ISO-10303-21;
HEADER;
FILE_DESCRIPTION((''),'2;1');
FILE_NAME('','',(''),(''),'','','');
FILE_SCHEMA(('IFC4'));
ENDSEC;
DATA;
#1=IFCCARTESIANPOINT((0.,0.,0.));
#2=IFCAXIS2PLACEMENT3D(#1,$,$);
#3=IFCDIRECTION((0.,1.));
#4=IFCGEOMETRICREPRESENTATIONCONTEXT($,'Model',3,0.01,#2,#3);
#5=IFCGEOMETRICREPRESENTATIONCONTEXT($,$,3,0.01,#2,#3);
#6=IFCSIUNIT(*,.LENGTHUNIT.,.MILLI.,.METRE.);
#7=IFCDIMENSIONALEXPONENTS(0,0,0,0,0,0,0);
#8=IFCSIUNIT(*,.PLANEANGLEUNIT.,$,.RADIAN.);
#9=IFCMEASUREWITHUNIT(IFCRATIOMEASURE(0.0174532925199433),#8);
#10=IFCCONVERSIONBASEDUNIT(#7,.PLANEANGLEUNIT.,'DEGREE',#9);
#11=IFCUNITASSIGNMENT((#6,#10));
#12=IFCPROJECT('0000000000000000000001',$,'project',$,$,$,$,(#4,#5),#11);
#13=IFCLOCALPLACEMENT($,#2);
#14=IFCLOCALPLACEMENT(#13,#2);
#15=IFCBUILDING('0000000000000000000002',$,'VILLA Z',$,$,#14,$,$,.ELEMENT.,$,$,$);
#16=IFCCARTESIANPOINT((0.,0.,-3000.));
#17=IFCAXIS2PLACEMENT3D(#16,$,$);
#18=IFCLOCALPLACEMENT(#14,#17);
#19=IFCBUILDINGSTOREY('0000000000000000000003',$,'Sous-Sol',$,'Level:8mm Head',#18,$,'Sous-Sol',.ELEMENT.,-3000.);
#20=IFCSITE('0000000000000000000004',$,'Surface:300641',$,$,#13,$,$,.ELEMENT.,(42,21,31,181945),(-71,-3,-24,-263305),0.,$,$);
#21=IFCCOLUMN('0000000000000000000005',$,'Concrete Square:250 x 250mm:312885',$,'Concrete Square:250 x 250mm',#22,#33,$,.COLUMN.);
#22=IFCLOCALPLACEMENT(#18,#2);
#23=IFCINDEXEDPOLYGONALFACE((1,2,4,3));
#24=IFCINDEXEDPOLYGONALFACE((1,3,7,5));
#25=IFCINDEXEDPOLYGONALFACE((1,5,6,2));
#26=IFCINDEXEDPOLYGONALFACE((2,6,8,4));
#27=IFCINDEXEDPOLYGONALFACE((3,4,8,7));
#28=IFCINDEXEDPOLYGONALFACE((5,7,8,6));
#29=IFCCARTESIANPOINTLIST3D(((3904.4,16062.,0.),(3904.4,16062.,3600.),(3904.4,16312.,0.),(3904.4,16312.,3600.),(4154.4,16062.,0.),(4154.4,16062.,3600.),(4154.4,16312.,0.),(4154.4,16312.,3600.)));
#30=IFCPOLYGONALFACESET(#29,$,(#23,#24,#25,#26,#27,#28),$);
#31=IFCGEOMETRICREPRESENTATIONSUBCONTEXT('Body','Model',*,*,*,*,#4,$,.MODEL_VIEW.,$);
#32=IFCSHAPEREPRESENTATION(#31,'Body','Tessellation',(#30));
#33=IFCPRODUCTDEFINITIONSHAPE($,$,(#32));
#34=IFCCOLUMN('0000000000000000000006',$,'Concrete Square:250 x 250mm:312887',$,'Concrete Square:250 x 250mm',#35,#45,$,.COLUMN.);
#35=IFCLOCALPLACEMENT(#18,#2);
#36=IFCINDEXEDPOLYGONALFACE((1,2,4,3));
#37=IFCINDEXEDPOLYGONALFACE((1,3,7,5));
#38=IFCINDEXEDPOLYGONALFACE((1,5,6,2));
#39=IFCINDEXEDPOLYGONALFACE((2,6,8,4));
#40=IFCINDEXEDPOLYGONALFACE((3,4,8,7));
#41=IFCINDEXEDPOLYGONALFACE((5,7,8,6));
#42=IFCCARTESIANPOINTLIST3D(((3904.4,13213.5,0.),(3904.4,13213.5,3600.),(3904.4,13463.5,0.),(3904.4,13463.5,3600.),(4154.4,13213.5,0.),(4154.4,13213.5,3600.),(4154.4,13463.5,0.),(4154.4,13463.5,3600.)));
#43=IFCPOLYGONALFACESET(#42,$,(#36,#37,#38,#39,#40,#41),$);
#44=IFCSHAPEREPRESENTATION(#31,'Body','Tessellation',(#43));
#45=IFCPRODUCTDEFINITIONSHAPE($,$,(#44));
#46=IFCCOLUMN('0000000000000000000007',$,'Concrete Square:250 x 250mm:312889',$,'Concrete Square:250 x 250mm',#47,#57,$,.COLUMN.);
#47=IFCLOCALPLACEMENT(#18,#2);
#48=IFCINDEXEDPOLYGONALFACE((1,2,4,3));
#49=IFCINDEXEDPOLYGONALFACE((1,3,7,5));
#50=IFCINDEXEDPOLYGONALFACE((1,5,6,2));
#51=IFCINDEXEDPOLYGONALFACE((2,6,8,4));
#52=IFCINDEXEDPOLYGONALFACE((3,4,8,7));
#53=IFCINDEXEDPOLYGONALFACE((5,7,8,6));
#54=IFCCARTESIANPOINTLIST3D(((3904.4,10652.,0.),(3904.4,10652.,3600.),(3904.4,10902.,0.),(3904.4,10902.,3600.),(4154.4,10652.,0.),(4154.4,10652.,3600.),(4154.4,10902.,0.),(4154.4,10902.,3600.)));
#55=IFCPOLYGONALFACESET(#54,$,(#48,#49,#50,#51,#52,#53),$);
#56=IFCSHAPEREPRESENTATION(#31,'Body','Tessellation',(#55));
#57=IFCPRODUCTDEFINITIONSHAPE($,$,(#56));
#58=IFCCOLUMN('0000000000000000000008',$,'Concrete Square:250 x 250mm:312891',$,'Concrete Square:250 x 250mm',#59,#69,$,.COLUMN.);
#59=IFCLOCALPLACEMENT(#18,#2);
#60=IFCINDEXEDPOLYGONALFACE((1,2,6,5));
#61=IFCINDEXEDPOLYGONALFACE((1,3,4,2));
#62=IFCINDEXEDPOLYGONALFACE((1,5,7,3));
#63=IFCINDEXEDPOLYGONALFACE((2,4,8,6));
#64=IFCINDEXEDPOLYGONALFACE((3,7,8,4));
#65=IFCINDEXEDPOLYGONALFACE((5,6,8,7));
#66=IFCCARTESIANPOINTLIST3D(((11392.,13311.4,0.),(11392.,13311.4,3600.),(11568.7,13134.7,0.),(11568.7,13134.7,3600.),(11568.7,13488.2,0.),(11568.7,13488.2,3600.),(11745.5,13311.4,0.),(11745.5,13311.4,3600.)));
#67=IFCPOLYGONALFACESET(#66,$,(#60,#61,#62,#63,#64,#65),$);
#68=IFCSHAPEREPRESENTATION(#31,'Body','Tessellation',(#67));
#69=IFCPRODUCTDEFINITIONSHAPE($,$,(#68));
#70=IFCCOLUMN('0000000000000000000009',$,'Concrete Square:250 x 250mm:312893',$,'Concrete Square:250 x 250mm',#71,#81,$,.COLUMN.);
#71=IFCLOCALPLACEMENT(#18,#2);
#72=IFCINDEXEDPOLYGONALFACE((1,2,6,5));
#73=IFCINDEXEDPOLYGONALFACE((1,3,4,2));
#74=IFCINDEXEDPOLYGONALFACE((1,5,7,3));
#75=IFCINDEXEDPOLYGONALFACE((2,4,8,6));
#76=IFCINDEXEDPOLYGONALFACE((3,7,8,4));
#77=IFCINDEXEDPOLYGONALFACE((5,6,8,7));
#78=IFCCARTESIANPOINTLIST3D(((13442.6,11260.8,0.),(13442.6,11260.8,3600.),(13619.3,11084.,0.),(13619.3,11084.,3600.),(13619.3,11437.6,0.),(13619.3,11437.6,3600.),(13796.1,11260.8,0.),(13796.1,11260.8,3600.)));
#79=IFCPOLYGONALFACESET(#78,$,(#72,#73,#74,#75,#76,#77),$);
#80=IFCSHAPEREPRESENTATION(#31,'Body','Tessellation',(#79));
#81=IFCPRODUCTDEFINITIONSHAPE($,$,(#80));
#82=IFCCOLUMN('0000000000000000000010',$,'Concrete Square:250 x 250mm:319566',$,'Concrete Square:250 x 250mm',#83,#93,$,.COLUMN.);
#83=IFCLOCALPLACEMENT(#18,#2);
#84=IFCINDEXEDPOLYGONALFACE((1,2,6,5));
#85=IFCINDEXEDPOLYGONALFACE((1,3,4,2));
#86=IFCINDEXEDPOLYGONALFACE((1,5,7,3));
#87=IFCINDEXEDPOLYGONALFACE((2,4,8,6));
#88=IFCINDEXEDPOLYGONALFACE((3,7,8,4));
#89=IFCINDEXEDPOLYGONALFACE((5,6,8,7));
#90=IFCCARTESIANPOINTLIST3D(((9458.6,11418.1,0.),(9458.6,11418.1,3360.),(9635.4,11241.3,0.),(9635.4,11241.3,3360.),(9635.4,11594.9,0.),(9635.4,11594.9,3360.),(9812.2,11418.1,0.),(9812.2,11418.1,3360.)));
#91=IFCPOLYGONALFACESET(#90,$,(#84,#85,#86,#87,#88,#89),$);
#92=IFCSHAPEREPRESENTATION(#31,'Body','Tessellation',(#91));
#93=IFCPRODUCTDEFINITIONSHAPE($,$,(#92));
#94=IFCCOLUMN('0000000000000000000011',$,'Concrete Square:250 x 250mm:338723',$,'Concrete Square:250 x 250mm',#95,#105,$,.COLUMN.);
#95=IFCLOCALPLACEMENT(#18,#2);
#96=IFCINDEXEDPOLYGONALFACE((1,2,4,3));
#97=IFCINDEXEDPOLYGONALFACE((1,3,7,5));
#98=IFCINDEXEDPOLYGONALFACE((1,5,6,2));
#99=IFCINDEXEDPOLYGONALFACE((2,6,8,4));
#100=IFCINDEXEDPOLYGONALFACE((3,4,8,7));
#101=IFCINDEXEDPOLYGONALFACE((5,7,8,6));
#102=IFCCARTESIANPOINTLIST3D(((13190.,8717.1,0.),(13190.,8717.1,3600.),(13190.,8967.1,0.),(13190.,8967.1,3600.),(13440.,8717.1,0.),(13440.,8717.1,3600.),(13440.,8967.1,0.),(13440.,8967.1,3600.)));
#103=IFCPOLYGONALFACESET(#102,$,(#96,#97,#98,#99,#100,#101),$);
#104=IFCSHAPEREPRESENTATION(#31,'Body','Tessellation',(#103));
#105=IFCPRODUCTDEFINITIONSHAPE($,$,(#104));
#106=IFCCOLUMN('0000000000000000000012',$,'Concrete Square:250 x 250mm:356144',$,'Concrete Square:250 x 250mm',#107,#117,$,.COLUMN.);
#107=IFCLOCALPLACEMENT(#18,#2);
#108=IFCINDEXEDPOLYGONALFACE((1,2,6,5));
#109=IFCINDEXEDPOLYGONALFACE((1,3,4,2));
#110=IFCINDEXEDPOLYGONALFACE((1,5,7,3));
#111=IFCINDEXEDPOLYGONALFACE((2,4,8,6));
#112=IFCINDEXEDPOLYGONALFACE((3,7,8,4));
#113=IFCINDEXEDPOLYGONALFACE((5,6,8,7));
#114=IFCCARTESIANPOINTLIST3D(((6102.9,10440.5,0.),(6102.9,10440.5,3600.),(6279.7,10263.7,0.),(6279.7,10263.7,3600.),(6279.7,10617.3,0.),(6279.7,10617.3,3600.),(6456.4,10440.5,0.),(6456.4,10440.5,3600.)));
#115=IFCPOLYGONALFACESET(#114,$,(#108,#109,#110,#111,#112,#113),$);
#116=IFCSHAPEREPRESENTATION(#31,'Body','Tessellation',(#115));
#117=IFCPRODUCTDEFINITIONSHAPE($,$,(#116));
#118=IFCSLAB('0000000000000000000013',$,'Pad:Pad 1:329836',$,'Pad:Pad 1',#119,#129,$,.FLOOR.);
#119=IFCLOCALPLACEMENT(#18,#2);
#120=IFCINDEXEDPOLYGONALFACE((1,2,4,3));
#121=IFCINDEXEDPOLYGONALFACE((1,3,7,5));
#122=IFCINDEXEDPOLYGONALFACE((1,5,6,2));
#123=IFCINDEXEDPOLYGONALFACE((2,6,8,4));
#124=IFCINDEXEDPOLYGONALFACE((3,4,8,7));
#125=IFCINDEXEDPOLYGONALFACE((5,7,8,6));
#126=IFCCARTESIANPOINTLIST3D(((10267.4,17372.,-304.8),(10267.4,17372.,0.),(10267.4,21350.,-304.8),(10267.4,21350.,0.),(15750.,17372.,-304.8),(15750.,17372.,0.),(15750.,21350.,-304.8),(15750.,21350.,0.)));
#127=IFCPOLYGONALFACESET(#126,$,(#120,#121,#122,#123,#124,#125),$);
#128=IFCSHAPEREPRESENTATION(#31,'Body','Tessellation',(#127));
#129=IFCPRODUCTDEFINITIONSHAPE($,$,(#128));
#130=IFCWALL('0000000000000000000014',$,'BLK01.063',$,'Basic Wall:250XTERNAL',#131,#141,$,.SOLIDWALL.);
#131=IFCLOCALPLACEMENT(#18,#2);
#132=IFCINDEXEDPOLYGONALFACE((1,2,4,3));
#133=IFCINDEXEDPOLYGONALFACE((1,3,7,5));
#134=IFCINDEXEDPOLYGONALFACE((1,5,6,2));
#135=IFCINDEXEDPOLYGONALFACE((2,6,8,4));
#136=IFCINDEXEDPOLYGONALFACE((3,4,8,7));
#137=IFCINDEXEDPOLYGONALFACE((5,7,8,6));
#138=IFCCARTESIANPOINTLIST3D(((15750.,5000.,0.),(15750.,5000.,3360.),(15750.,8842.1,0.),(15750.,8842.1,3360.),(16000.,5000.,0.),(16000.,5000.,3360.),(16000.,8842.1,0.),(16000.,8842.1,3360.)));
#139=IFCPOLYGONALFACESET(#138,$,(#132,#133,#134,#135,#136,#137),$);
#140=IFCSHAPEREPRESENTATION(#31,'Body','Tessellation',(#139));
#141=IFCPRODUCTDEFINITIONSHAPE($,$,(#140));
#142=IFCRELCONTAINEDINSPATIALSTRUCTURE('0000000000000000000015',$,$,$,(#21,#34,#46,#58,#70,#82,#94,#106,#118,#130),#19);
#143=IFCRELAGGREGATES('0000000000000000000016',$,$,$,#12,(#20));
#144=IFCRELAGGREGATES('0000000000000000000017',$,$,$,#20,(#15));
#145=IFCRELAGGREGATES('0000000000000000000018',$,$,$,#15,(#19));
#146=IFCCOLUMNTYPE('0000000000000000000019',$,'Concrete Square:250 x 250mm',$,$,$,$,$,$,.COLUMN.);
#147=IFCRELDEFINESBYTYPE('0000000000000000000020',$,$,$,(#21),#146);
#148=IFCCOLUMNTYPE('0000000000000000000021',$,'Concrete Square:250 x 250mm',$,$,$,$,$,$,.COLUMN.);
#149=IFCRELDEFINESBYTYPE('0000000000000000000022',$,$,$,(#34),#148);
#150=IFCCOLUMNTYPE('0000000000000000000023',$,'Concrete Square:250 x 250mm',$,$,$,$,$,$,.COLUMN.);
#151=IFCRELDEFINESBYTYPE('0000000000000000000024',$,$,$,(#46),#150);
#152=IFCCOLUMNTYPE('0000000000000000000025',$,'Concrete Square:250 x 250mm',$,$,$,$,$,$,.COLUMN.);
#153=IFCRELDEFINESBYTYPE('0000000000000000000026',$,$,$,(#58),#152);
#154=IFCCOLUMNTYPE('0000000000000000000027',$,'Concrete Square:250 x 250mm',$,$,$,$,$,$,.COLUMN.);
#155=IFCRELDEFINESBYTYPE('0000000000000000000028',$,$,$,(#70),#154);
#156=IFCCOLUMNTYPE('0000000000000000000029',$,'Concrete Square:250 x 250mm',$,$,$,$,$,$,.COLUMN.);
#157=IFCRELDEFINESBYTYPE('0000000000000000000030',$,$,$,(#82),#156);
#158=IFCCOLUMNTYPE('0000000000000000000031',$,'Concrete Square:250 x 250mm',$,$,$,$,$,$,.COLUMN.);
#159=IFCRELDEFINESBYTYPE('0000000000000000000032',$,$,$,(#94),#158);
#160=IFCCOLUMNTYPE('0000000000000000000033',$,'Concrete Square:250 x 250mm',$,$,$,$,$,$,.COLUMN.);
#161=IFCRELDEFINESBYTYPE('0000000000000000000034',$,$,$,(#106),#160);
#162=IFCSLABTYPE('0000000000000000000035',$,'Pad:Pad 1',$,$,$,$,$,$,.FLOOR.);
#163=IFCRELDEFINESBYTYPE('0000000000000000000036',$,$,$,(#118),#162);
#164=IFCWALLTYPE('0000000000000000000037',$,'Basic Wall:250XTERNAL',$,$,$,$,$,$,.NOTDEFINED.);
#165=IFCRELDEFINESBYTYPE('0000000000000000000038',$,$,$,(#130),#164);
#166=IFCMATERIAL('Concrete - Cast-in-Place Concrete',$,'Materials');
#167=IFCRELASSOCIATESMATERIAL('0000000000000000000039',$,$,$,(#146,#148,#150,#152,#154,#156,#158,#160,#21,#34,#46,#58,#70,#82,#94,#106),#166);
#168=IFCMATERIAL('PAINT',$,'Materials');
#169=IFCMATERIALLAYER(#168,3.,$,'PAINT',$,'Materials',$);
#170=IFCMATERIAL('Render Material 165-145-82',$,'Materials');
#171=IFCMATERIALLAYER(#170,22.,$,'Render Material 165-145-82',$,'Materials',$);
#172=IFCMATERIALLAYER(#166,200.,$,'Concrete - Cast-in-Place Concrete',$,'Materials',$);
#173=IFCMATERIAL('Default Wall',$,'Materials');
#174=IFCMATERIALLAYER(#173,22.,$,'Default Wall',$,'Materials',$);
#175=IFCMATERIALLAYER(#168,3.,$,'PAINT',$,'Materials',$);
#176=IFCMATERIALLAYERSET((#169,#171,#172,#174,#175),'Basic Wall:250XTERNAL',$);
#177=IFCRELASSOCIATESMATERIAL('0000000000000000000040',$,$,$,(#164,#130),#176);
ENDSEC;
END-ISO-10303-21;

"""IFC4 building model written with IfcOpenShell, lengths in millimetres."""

from ifc_helpers import new_model, entity, si_unit, converted_unit, direction, frame, frame_2d, origin, origin_2d_with_axis, place, context, subcontext, project, spatial, polyline, rectangle, extrude, clip, halfspace, bounded_halfspace, source, transform, mapped, material, layer, layer_set, layer_usage, material_profile, profile_set, profile_usage, type_object, type_shapes, element, save


model = new_model("IFC4")

# Units and contexts
model_context = context("Model", 3, precision=0.01, world=origin(), true_north=direction((0.0, 1.0)))
context_of_model = context(None, 3, precision=0.01, world=origin(), true_north=direction((0.0, 1.0)))
body_context = subcontext(model_context, "Body", "Model", "MODEL_VIEW")
ifc_project = project(units=[si_unit("LENGTHUNIT", "METRE", prefix="MILLI"), converted_unit("PLANEANGLEUNIT", "DEGREE", entity("IfcRatioMeasure", 0.0174532925199433), si_unit("PLANEANGLEUNIT", "RADIAN"), dimensions=[0, 0, 0, 0, 0, 0, 0])], contexts=[model_context, context_of_model])

# Site, building, storey
site_placement = place(None, origin())
site = spatial("IfcSite", under=ifc_project, at=site_placement, Name="Surface:300641", CompositionType="ELEMENT", RefLatitude=(42, 21, 31, 181945), RefLongitude=(-71, -3, -24, -263305), RefElevation=0.0)
building_placement = place(site_placement, origin())
building = spatial("IfcBuilding", under=site, at=building_placement, Name="VILLA Z", CompositionType="ELEMENT")
storey_placement = place(building_placement, frame((0.0, 0.0, -3000.0)))
storey = spatial("IfcBuildingStorey", under=building, at=storey_placement, Name="Sous-Sol", ObjectType="Level:8mm Head", LongName="Sous-Sol", CompositionType="ELEMENT", Elevation=-3000.0)

# Columns
ifc_material_1 = material(Name="Concrete - Cast-in-Place Concrete", Category="Materials")
ifc_material_profile = material_profile(ifc_material_1, rectangle(XDim=250.0, YDim=250.0, at=frame_2d((0.0, 0.0), x_axis=(1.0, 0.0))), Name="250 x 250mm")
ifc_profile_set = profile_set([ifc_material_profile], Name="250 x 250mm")
ifc_profile_usage_1 = profile_usage(ifc_profile_set)
column_type_1 = type_object("IfcColumnType", Name="Concrete Square:250 x 250mm", PredefinedType="COLUMN", material=ifc_profile_set)
shared_shape_1 = source(origin(), body_context, "Body", "SweptSolid", [
    extrude(rectangle(XDim=250.0, YDim=250.0, at=frame_2d((0.0, 0.0), x_axis=(1.0, 0.0))), frame((4029.4, 16187.0, -3000.0), z_axis=(0.0, 0.0, 1.0), x_axis=(0.0, -1.0, 0.0)), (0.0, 0.0, 1.0), 3600.0),
])
type_shapes(column_type_1, [shared_shape_1])
column_1_placement = place(storey_placement, frame((0.0, 0.0, 3000.0)))
element("IfcColumn", 1, at=column_1_placement, inside=storey, type_object=column_type_1, material=ifc_profile_usage_1, Name="Concrete Square:250 x 250mm:312885", ObjectType="Concrete Square:250 x 250mm", PredefinedType="COLUMN", context=body_context, shape_type="MappedRepresentation", body=[
    mapped(shared_shape_1, transform((0.0, 0.0, 0.0), scale=1.0)),
])
ifc_profile_usage_2 = profile_usage(ifc_profile_set)
column_type_2 = type_object("IfcColumnType", Name="Concrete Square:250 x 250mm", PredefinedType="COLUMN", material=ifc_profile_set)
shared_shape_2 = source(origin(), body_context, "Body", "SweptSolid", [
    extrude(rectangle(XDim=250.0, YDim=250.0, at=frame_2d((0.0, 0.0), x_axis=(1.0, 0.0))), frame((4029.4, 13338.5, -3000.0), z_axis=(0.0, 0.0, 1.0), x_axis=(0.0, -1.0, 0.0)), (0.0, 0.0, 1.0), 3600.0),
])
type_shapes(column_type_2, [shared_shape_2])
column_2_placement = place(storey_placement, frame((0.0, 0.0, 3000.0)))
element("IfcColumn", 2, at=column_2_placement, inside=storey, type_object=column_type_2, material=ifc_profile_usage_2, Name="Concrete Square:250 x 250mm:312887", ObjectType="Concrete Square:250 x 250mm", PredefinedType="COLUMN", context=body_context, shape_type="MappedRepresentation", body=[
    mapped(shared_shape_2, transform((0.0, 0.0, 0.0), scale=1.0)),
])
ifc_profile_usage_3 = profile_usage(ifc_profile_set)
column_type_3 = type_object("IfcColumnType", Name="Concrete Square:250 x 250mm", PredefinedType="COLUMN", material=ifc_profile_set)
shared_shape_3 = source(origin(), body_context, "Body", "SweptSolid", [
    extrude(rectangle(XDim=250.0, YDim=250.0, at=frame_2d((0.0, 0.0), x_axis=(1.0, 0.0))), frame((4029.4, 10777.0, -3000.0), z_axis=(0.0, 0.0, 1.0), x_axis=(0.0, -1.0, 0.0)), (0.0, 0.0, 1.0), 3600.0),
])
type_shapes(column_type_3, [shared_shape_3])
column_3_placement = place(storey_placement, frame((0.0, 0.0, 3000.0)))
element("IfcColumn", 3, at=column_3_placement, inside=storey, type_object=column_type_3, material=ifc_profile_usage_3, Name="Concrete Square:250 x 250mm:312889", ObjectType="Concrete Square:250 x 250mm", PredefinedType="COLUMN", context=body_context, shape_type="MappedRepresentation", body=[
    mapped(shared_shape_3, transform((0.0, 0.0, 0.0), scale=1.0)),
])
ifc_profile_usage_4 = profile_usage(ifc_profile_set)
column_type_4 = type_object("IfcColumnType", Name="Concrete Square:250 x 250mm", PredefinedType="COLUMN", material=ifc_profile_set)
shared_shape_4 = source(origin(), body_context, "Body", "SweptSolid", [
    extrude(rectangle(XDim=250.0, YDim=250.0, at=origin_2d_with_axis()), frame((11568.7, 13311.4, -3000.0), z_axis=(0.0, 0.0, 1.0), x_axis=(-0.707107, 0.707107, 0.0)), (0.0, 0.0, 1.0), 3600.0),
])
type_shapes(column_type_4, [shared_shape_4])
column_4_placement = place(storey_placement, frame((0.0, 0.0, 3000.0)))
element("IfcColumn", 4, at=column_4_placement, inside=storey, type_object=column_type_4, material=ifc_profile_usage_4, Name="Concrete Square:250 x 250mm:312891", ObjectType="Concrete Square:250 x 250mm", PredefinedType="COLUMN", context=body_context, shape_type="MappedRepresentation", body=[
    mapped(shared_shape_4, transform((0.0, 0.0, 0.0), scale=1.0)),
])
ifc_profile_usage_5 = profile_usage(ifc_profile_set)
column_type_5 = type_object("IfcColumnType", Name="Concrete Square:250 x 250mm", PredefinedType="COLUMN", material=ifc_profile_set)
shared_shape_5 = source(origin(), body_context, "Body", "SweptSolid", [
    extrude(rectangle(XDim=250.0, YDim=250.0, at=frame_2d((0.0, 0.0), x_axis=(1.0, 0.0))), frame((13619.3, 11260.8, -3000.0), z_axis=(0.0, 0.0, 1.0), x_axis=(-0.707107, 0.707107, 0.0)), (0.0, 0.0, 1.0), 3600.0),
])
type_shapes(column_type_5, [shared_shape_5])
column_5_placement = place(storey_placement, frame((0.0, 0.0, 3000.0)))
element("IfcColumn", 5, at=column_5_placement, inside=storey, type_object=column_type_5, material=ifc_profile_usage_5, Name="Concrete Square:250 x 250mm:312893", ObjectType="Concrete Square:250 x 250mm", PredefinedType="COLUMN", context=body_context, shape_type="MappedRepresentation", body=[
    mapped(shared_shape_5, transform((0.0, 0.0, 0.0), scale=1.0)),
])
ifc_profile_usage_6 = profile_usage(ifc_profile_set)
column_type_6 = type_object("IfcColumnType", Name="Concrete Square:250 x 250mm", PredefinedType="COLUMN", material=ifc_profile_set)
shared_shape_6 = source(origin(), body_context, "Body", "SweptSolid", [
    extrude(rectangle(XDim=250.0, YDim=250.0, at=frame_2d((0.0, 0.0), x_axis=(1.0, 0.0))), frame((9635.4, 11418.1, -3000.0), z_axis=(0.0, 0.0, 1.0), x_axis=(-0.707107, 0.707107, 0.0)), (0.0, 0.0, 1.0), 3360.0),
])
type_shapes(column_type_6, [shared_shape_6])
column_6_placement = place(storey_placement, frame((0.0, 0.0, 3000.0)))
element("IfcColumn", 6, at=column_6_placement, inside=storey, type_object=column_type_6, material=ifc_profile_usage_6, Name="Concrete Square:250 x 250mm:319566", ObjectType="Concrete Square:250 x 250mm", PredefinedType="COLUMN", context=body_context, shape_type="MappedRepresentation", body=[
    mapped(shared_shape_6, transform((0.0, 0.0, 0.0), scale=1.0)),
])
ifc_profile_usage_7 = profile_usage(ifc_profile_set)
column_type_7 = type_object("IfcColumnType", Name="Concrete Square:250 x 250mm", PredefinedType="COLUMN", material=ifc_profile_set)
shared_shape_7 = source(origin(), body_context, "Body", "SweptSolid", [
    extrude(rectangle(XDim=250.0, YDim=250.0, at=frame_2d((0.0, 0.0), x_axis=(1.0, 0.0))), frame((13315.0, 8842.1, -3000.0), z_axis=(0.0, 0.0, 1.0), x_axis=(0.0, -1.0, 0.0)), (0.0, 0.0, 1.0), 3600.0),
])
type_shapes(column_type_7, [shared_shape_7])
column_7_placement = place(storey_placement, frame((0.0, 0.0, 3000.0)))
element("IfcColumn", 7, at=column_7_placement, inside=storey, type_object=column_type_7, material=ifc_profile_usage_7, Name="Concrete Square:250 x 250mm:338723", ObjectType="Concrete Square:250 x 250mm", PredefinedType="COLUMN", context=body_context, shape_type="MappedRepresentation", body=[
    mapped(shared_shape_7, transform((0.0, 0.0, 0.0), scale=1.0)),
])
ifc_profile_usage_8 = profile_usage(ifc_profile_set)
column_type_8 = type_object("IfcColumnType", Name="Concrete Square:250 x 250mm", PredefinedType="COLUMN", material=ifc_profile_set)
shared_shape_8 = source(origin(), body_context, "Body", "SweptSolid", [
    extrude(rectangle(XDim=250.0, YDim=250.0, at=origin_2d_with_axis()), frame((6279.7, 10440.5, -3000.0), z_axis=(0.0, 0.0, 1.0), x_axis=(-0.707107, 0.707107, 0.0)), (0.0, 0.0, 1.0), 3600.0),
])
type_shapes(column_type_8, [shared_shape_8])
column_8_placement = place(storey_placement, frame((0.0, 0.0, 3000.0)))
element("IfcColumn", 8, at=column_8_placement, inside=storey, type_object=column_type_8, material=ifc_profile_usage_8, Name="Concrete Square:250 x 250mm:356144", ObjectType="Concrete Square:250 x 250mm", PredefinedType="COLUMN", context=body_context, shape_type="MappedRepresentation", body=[
    mapped(shared_shape_8, transform((0.0, 0.0, 0.0), scale=1.0)),
])

# Slab
slab_type_1 = type_object("IfcSlabType", Name="Pad:Pad 1", PredefinedType="FLOOR")
slab_1_placement = place(storey_placement, origin())
element("IfcSlab", 9, at=slab_1_placement, inside=storey, type_object=slab_type_1, Name="Pad:Pad 1:329836", ObjectType="Pad:Pad 1", PredefinedType="FLOOR", context=body_context, shape_type="SweptSolid", body=[
    extrude(rectangle(XDim=5482.6, YDim=3978.0, at=frame_2d((0.0, 0.0), x_axis=(1.0, 0.0))), frame((13008.7, 19361.0, -304.8)), (0.0, 0.0, 1.0), 304.8),
])

# Wall
ifc_material_2 = material(Name="PAINT", Category="Materials")
ifc_layer_1 = layer(ifc_material_2, 3.0, Name="PAINT", Category="Materials")
ifc_material_3 = material(Name="Render Material 165-145-82", Category="Materials")
ifc_layer_2 = layer(ifc_material_3, 22.0, Name="Render Material 165-145-82", Category="Materials")
ifc_layer_3 = layer(ifc_material_1, 200.0, Name="Concrete - Cast-in-Place Concrete", Category="Materials")
ifc_material_4 = material(Name="Default Wall", Category="Materials")
ifc_layer_4 = layer(ifc_material_4, 22.0, Name="Default Wall", Category="Materials")
ifc_layer_5 = layer(ifc_material_2, 3.0, Name="PAINT", Category="Materials")
ifc_layer_set = layer_set([ifc_layer_1, ifc_layer_2, ifc_layer_3, ifc_layer_4, ifc_layer_5], Name="Basic Wall:250XTERNAL")
ifc_layer_usage_1 = layer_usage(ifc_layer_set, "AXIS2", "NEGATIVE", 125.0)
wall_type = type_object("IfcWallType", Name="Basic Wall:250XTERNAL", PredefinedType="NOTDEFINED", material=ifc_layer_set)
wall_1_placement = place(storey_placement, frame((15875.0, 5000.0, 0.0), z_axis=(0.0, 0.0, 1.0), x_axis=(0.0, 1.0, 0.0)))
element("IfcWall", 10, at=wall_1_placement, inside=storey, type_object=wall_type, material=ifc_layer_usage_1, Name="BLK01.063", ObjectType="Basic Wall:250XTERNAL", PredefinedType="SOLIDWALL", context=body_context, shape_type="Clipping", body=[
    clip(clip(extrude(rectangle(XDim=3842.1, YDim=250.0, at=frame_2d((1921.1, 0.0), x_axis=(-1.0, 0.0))), origin(), (0.0, 0.0, 1.0), 3360.0), bounded_halfspace(frame((0.0, 125.0, 3360.0), z_axis=(0.0, 0.0, -1.0), x_axis=(-1.0, 0.0, 0.0)), True, frame((0.0, 125.0, 3360.0)), polyline([(0.0, 0.0), (0.0, -250.0), (125.0, -250.0), (3842.1, -250.0), (3842.1, 0.0), (150.0, 0.0), (125.0, 0.0), (0.0, 0.0)]))), halfspace(origin(), True)),
])

save(model, "model.ifc")
